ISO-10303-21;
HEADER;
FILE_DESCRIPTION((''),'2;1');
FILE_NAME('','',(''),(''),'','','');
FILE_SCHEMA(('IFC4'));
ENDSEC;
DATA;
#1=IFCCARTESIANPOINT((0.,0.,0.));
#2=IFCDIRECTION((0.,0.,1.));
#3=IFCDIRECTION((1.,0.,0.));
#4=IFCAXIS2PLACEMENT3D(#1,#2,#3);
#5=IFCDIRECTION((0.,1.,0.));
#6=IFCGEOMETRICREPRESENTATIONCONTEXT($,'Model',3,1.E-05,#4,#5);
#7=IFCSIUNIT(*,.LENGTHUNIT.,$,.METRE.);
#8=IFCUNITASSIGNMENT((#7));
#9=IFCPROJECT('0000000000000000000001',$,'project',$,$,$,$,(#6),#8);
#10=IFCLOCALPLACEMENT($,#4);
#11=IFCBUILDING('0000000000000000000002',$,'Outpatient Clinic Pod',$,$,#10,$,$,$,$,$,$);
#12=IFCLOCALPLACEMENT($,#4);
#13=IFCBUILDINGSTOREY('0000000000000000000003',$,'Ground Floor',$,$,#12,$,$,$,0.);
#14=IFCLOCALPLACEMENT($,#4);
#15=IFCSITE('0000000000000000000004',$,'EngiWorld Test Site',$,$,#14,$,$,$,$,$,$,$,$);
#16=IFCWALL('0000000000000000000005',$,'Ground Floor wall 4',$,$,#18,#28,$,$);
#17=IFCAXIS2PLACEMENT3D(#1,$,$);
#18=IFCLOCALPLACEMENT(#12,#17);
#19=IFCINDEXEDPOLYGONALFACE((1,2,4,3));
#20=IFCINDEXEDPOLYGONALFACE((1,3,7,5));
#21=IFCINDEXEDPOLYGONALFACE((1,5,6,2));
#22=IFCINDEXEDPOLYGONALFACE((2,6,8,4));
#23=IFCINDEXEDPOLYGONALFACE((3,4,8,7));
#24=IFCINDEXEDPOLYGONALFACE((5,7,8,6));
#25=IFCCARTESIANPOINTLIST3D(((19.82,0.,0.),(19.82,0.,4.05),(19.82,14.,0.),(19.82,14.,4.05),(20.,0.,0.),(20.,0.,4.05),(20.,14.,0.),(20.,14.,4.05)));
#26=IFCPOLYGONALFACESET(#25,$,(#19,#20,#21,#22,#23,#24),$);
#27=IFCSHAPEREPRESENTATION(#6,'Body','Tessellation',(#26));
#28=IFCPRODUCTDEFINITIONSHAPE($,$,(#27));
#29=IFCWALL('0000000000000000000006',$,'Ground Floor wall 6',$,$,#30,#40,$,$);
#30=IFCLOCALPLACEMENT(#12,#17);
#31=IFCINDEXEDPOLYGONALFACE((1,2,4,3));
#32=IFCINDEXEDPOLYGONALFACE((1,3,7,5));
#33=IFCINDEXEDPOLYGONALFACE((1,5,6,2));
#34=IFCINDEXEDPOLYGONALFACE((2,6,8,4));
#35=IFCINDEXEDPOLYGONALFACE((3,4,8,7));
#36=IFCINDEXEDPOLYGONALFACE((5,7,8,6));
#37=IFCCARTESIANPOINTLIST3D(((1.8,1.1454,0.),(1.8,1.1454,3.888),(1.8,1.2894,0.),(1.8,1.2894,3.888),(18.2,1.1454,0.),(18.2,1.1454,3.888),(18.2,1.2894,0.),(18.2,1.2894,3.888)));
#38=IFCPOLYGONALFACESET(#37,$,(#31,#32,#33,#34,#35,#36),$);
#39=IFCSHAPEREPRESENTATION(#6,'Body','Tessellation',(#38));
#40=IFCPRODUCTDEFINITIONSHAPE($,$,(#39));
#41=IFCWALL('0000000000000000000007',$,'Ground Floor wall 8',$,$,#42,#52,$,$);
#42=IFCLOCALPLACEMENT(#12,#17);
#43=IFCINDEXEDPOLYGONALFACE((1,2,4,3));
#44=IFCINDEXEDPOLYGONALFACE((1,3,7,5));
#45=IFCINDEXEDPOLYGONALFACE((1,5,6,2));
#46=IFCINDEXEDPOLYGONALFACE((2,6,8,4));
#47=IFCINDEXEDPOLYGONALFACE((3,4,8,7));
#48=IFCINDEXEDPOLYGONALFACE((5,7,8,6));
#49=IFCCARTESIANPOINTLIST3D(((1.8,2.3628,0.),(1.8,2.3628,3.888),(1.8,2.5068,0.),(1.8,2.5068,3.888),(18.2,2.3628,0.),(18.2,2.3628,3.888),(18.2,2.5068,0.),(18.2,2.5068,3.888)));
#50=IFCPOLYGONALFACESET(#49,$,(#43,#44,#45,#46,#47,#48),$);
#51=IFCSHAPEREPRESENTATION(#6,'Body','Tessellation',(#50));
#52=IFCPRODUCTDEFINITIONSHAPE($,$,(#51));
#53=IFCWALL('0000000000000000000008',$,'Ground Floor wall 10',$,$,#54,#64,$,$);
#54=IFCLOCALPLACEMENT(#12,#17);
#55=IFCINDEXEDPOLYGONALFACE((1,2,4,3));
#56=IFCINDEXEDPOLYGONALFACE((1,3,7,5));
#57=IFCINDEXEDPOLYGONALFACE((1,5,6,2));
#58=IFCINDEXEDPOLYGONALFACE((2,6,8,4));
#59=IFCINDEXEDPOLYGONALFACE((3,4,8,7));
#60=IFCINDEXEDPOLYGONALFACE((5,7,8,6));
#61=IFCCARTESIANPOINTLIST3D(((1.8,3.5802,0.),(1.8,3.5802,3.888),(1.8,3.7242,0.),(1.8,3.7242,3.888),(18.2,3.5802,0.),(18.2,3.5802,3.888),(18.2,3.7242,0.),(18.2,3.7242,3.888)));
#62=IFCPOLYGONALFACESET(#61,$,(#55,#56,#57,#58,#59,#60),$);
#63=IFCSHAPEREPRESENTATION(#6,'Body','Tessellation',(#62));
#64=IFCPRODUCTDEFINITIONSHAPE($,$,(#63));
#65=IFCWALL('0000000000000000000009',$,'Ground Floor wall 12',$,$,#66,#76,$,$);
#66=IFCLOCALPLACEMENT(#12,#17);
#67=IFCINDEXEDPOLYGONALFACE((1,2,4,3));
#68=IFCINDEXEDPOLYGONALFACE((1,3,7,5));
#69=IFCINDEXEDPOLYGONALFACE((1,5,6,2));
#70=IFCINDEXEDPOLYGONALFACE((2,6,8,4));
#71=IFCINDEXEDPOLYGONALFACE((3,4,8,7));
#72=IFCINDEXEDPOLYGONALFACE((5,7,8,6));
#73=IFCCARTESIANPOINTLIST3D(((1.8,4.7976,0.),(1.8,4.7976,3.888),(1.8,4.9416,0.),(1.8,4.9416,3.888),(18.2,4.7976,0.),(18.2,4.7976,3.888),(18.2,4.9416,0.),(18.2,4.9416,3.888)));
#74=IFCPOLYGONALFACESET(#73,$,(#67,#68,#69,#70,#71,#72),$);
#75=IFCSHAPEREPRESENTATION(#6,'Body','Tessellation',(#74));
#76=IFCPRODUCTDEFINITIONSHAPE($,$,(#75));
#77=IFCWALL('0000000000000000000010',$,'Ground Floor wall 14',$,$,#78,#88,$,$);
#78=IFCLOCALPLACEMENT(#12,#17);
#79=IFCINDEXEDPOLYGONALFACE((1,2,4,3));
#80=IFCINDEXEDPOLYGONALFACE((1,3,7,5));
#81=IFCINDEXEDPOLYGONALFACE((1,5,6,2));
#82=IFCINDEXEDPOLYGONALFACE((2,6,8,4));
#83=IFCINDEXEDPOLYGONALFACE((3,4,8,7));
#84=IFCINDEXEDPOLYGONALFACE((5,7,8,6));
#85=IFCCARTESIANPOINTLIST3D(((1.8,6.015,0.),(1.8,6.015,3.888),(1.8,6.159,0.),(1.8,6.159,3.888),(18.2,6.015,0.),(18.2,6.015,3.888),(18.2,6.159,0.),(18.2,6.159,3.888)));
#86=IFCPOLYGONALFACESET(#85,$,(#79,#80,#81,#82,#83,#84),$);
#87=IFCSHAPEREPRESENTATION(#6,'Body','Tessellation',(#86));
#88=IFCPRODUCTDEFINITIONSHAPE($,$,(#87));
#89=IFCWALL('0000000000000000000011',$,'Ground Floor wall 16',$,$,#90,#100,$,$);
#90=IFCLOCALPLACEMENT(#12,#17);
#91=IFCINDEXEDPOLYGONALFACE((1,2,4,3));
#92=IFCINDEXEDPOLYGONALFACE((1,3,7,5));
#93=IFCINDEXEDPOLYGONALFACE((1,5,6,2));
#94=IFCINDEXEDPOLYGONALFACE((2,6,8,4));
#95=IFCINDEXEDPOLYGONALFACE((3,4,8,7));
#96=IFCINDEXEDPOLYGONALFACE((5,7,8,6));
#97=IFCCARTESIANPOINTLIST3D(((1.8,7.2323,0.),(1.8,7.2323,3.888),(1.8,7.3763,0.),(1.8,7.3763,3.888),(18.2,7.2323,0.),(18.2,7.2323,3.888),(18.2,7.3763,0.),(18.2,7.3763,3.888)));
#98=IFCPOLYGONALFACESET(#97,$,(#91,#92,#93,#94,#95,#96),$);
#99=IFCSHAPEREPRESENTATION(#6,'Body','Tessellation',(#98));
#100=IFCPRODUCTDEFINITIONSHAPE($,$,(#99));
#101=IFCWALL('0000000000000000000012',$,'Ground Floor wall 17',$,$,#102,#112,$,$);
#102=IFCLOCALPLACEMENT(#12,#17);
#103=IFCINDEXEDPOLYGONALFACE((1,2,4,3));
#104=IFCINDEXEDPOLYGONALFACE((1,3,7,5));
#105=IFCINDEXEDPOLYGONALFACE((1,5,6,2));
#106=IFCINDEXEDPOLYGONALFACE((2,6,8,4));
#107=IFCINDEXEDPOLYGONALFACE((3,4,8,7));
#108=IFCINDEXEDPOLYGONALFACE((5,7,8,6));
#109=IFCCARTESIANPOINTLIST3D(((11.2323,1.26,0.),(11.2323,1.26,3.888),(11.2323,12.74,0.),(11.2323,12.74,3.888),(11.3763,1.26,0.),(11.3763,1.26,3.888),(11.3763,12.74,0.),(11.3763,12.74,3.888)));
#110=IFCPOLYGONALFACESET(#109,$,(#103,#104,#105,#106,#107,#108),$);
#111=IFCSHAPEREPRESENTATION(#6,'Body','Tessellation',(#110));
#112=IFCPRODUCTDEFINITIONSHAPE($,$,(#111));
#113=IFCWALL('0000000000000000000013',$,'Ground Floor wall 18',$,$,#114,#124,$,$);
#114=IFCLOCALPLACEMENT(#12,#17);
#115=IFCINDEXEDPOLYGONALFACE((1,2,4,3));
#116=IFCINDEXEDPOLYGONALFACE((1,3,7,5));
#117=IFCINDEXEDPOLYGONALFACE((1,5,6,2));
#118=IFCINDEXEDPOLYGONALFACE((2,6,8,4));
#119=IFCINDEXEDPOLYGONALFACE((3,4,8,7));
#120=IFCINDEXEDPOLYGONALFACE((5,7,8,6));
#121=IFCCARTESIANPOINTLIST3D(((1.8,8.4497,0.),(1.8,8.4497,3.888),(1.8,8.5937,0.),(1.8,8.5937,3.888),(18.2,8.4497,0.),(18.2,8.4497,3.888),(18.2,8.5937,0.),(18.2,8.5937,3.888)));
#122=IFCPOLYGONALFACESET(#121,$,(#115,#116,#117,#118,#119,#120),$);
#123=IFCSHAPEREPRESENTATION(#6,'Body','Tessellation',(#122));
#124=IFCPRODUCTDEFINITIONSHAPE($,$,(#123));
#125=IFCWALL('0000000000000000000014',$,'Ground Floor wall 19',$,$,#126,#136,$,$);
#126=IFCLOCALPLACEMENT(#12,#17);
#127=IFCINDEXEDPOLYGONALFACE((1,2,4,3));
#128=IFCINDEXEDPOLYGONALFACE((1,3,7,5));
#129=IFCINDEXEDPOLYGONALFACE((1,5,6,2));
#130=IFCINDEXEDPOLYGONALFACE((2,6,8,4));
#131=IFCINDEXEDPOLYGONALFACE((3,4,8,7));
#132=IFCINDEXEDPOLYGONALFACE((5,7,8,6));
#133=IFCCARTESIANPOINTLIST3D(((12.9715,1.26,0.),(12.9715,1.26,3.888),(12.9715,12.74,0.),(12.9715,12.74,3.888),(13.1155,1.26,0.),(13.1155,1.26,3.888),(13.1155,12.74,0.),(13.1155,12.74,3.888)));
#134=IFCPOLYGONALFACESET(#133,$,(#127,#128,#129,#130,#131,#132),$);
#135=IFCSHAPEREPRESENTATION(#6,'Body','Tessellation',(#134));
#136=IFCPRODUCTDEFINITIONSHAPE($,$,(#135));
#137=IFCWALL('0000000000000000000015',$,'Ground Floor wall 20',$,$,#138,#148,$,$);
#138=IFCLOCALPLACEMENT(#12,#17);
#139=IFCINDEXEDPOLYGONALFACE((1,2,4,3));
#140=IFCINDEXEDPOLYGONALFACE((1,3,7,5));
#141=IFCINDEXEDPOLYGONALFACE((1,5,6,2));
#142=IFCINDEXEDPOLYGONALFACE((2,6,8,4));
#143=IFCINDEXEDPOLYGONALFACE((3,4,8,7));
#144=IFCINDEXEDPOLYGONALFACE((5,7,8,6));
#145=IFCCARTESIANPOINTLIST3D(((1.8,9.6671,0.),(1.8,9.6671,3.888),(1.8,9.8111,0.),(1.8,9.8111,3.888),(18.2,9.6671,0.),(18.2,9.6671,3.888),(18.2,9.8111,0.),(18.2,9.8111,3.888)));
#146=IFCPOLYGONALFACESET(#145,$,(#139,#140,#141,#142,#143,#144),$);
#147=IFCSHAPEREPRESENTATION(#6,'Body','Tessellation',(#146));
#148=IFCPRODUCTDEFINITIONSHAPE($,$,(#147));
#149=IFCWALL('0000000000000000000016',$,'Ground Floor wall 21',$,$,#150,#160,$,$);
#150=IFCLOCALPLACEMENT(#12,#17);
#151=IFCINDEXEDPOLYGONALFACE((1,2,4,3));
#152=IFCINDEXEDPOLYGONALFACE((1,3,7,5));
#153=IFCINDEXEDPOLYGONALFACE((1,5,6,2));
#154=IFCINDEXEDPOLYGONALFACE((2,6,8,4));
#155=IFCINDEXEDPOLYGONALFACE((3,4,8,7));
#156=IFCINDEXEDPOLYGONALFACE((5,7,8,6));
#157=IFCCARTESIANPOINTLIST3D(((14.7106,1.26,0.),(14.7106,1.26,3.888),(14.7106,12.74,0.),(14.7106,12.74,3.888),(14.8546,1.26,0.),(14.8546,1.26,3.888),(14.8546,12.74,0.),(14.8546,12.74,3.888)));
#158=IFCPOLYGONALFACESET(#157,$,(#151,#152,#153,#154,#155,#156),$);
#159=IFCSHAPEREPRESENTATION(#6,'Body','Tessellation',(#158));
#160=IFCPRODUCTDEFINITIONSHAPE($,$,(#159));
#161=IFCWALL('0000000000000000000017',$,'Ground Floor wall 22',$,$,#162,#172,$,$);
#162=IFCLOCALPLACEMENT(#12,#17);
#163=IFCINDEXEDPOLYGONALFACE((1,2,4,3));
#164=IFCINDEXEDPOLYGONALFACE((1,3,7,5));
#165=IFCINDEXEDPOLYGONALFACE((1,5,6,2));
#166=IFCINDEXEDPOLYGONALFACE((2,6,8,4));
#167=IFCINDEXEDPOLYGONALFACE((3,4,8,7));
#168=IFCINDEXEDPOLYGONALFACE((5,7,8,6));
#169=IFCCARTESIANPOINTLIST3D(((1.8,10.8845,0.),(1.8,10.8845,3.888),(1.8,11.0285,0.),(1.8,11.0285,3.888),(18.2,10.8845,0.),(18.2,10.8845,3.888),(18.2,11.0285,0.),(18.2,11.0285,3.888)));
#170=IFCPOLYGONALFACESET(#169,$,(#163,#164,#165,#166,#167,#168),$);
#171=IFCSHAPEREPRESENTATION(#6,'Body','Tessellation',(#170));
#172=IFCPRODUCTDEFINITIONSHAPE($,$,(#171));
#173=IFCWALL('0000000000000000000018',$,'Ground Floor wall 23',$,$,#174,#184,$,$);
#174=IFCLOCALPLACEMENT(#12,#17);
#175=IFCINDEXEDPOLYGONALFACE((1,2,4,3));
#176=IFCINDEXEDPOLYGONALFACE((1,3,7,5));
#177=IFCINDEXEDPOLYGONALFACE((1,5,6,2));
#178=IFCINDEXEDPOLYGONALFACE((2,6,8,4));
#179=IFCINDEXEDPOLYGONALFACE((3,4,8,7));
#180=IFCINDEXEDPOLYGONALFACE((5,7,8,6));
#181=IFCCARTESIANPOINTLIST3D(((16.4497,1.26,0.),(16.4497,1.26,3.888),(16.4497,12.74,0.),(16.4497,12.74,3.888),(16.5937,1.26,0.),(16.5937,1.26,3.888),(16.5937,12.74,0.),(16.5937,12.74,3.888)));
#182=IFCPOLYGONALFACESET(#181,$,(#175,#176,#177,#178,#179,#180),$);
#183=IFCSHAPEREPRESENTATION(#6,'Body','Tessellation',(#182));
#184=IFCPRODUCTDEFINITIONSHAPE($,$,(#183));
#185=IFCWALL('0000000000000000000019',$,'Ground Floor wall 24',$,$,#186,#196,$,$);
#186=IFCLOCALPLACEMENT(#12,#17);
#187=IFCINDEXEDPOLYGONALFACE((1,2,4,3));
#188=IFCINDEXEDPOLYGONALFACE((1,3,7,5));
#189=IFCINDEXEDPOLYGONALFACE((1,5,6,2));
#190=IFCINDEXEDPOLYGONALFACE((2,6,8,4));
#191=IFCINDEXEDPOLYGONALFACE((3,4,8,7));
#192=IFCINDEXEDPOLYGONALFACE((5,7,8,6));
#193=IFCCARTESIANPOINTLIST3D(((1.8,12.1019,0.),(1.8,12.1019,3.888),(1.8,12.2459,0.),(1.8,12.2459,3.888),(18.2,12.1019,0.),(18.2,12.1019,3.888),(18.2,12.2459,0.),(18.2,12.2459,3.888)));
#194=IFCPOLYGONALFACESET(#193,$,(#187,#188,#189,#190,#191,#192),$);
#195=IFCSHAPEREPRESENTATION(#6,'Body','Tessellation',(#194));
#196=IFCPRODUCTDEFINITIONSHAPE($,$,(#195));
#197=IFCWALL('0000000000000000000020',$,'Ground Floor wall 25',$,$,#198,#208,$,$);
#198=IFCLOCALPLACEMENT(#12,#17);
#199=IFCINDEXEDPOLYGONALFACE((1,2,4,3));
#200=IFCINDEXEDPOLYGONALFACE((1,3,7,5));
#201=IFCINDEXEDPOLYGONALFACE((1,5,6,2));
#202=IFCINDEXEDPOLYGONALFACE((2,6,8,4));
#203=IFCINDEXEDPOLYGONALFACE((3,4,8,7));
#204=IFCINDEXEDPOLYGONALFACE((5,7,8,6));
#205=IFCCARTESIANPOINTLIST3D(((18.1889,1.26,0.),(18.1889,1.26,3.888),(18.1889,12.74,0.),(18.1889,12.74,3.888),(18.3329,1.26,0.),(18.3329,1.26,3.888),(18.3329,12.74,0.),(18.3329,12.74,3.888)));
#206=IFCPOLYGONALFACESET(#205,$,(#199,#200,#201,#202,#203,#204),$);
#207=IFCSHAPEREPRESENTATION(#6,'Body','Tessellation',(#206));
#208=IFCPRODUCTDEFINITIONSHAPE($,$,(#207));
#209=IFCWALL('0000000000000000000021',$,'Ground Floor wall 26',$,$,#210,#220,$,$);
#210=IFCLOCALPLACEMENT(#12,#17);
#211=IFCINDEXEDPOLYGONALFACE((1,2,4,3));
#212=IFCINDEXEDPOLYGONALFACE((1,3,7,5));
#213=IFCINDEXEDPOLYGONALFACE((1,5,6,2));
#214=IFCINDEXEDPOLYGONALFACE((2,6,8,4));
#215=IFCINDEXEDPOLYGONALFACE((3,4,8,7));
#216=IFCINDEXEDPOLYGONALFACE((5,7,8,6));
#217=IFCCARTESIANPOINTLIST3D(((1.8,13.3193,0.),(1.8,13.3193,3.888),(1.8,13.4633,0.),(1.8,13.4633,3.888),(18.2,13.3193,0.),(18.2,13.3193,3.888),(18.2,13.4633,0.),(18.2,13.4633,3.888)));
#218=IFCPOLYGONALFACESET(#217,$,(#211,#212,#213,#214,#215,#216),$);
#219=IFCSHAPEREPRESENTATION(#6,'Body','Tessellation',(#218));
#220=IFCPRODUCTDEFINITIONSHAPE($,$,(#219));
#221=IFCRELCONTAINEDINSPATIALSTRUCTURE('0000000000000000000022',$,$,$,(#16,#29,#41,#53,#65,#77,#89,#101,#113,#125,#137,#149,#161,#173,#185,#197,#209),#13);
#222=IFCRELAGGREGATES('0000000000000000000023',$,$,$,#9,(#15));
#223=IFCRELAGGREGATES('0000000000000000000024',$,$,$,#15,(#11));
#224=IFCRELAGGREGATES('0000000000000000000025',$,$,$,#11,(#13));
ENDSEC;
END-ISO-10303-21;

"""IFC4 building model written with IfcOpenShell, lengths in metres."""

from ifc_helpers import new_model, si_unit, direction, frame, origin_with_axes, origin_2d_with_axis, place, context, project, spatial, rectangle, extrude, element, save


model = new_model("IFC4")

# Units and contexts
model_context = context("Model", 3, precision=1e-05, world=origin_with_axes(), true_north=direction((0.0, 1.0, 0.0)))
ifc_project = project(units=[si_unit("LENGTHUNIT", "METRE")], contexts=[model_context])

# Site, building, storey
site_placement = place(None, origin_with_axes())
site = spatial("IfcSite", under=ifc_project, at=site_placement, Name="EngiWorld Test Site")
building_placement = place(None, origin_with_axes())
building = spatial("IfcBuilding", under=site, at=building_placement, Name="Outpatient Clinic Pod")
storey_placement = place(None, origin_with_axes())
storey = spatial("IfcBuildingStorey", under=building, at=storey_placement, Name="Ground Floor", Elevation=0.0)

# Walls
wall_1_placement = place(None, frame((19.91, 7.0, 0.0), z_axis=(0.0, 0.0, 1.0), x_axis=(1.0, 0.0, 0.0)))
element("IfcWall", 1, at=wall_1_placement, inside=storey, Name="Ground Floor wall 4", context=model_context, shape_type="SweptSolid", body=[
    extrude(rectangle(XDim=0.18, YDim=14.0, at=origin_2d_with_axis()), origin_with_axes(), (0.0, 0.0, 1.0), 4.05),
])
for number, where, z_axis, x_axis, name in (
    (2, (10.0, 1.2174, 0.0), (0.0, 0.0, 1.0), (1.0, 0.0, 0.0), "Ground Floor wall 6"),
    (3, (10.0, 2.4348, 0.0), (0.0, 0.0, 1.0), (1.0, 0.0, 0.0), "Ground Floor wall 8"),
    (4, (10.0, 3.6522, 0.0), (0.0, 0.0, 1.0), (1.0, 0.0, 0.0), "Ground Floor wall 10"),
    (5, (10.0, 4.8696, 0.0), (0.0, 0.0, 1.0), (1.0, 0.0, 0.0), "Ground Floor wall 12"),
    (6, (10.0, 6.087, 0.0), (0.0, 0.0, 1.0), (1.0, 0.0, 0.0), "Ground Floor wall 14"),
    (7, (10.0, 7.3043, 0.0), (0.0, 0.0, 1.0), (1.0, 0.0, 0.0), "Ground Floor wall 16"),
):
    element("IfcWall", number, at=place(None, frame(where, z_axis=z_axis, x_axis=x_axis)), inside=storey, Name=name, context=model_context, shape_type="SweptSolid", body=[
        extrude(rectangle(XDim=16.4, YDim=0.144, at=origin_2d_with_axis()), origin_with_axes(), (0.0, 0.0, 1.0), 3.888),
    ])
wall_2_placement = place(None, frame((11.3043, 7.0, 0.0), z_axis=(0.0, 0.0, 1.0), x_axis=(1.0, 0.0, 0.0)))
element("IfcWall", 8, at=wall_2_placement, inside=storey, Name="Ground Floor wall 17", context=model_context, shape_type="SweptSolid", body=[
    extrude(rectangle(XDim=0.144, YDim=11.48, at=origin_2d_with_axis()), origin_with_axes(), (0.0, 0.0, 1.0), 3.888),
])
wall_3_placement = place(None, frame((10.0, 8.5217, 0.0), z_axis=(0.0, 0.0, 1.0), x_axis=(1.0, 0.0, 0.0)))
element("IfcWall", 9, at=wall_3_placement, inside=storey, Name="Ground Floor wall 18", context=model_context, shape_type="SweptSolid", body=[
    extrude(rectangle(XDim=16.4, YDim=0.144, at=origin_2d_with_axis()), origin_with_axes(), (0.0, 0.0, 1.0), 3.888),
])
wall_4_placement = place(None, frame((13.0435, 7.0, 0.0), z_axis=(0.0, 0.0, 1.0), x_axis=(1.0, 0.0, 0.0)))
element("IfcWall", 10, at=wall_4_placement, inside=storey, Name="Ground Floor wall 19", context=model_context, shape_type="SweptSolid", body=[
    extrude(rectangle(XDim=0.144, YDim=11.48, at=origin_2d_with_axis()), origin_with_axes(), (0.0, 0.0, 1.0), 3.888),
])
wall_5_placement = place(None, frame((10.0, 9.7391, 0.0), z_axis=(0.0, 0.0, 1.0), x_axis=(1.0, 0.0, 0.0)))
element("IfcWall", 11, at=wall_5_placement, inside=storey, Name="Ground Floor wall 20", context=model_context, shape_type="SweptSolid", body=[
    extrude(rectangle(XDim=16.4, YDim=0.144, at=origin_2d_with_axis()), origin_with_axes(), (0.0, 0.0, 1.0), 3.888),
])
wall_6_placement = place(None, frame((14.7826, 7.0, 0.0), z_axis=(0.0, 0.0, 1.0), x_axis=(1.0, 0.0, 0.0)))
element("IfcWall", 12, at=wall_6_placement, inside=storey, Name="Ground Floor wall 21", context=model_context, shape_type="SweptSolid", body=[
    extrude(rectangle(XDim=0.144, YDim=11.48, at=origin_2d_with_axis()), origin_with_axes(), (0.0, 0.0, 1.0), 3.888),
])
wall_7_placement = place(None, frame((10.0, 10.9565, 0.0), z_axis=(0.0, 0.0, 1.0), x_axis=(1.0, 0.0, 0.0)))
element("IfcWall", 13, at=wall_7_placement, inside=storey, Name="Ground Floor wall 22", context=model_context, shape_type="SweptSolid", body=[
    extrude(rectangle(XDim=16.4, YDim=0.144, at=origin_2d_with_axis()), origin_with_axes(), (0.0, 0.0, 1.0), 3.888),
])
wall_8_placement = place(None, frame((16.5217, 7.0, 0.0), z_axis=(0.0, 0.0, 1.0), x_axis=(1.0, 0.0, 0.0)))
element("IfcWall", 14, at=wall_8_placement, inside=storey, Name="Ground Floor wall 23", context=model_context, shape_type="SweptSolid", body=[
    extrude(rectangle(XDim=0.144, YDim=11.48, at=origin_2d_with_axis()), origin_with_axes(), (0.0, 0.0, 1.0), 3.888),
])
wall_9_placement = place(None, frame((10.0, 12.1739, 0.0), z_axis=(0.0, 0.0, 1.0), x_axis=(1.0, 0.0, 0.0)))
element("IfcWall", 15, at=wall_9_placement, inside=storey, Name="Ground Floor wall 24", context=model_context, shape_type="SweptSolid", body=[
    extrude(rectangle(XDim=16.4, YDim=0.144, at=origin_2d_with_axis()), origin_with_axes(), (0.0, 0.0, 1.0), 3.888),
])
wall_10_placement = place(None, frame((18.2609, 7.0, 0.0), z_axis=(0.0, 0.0, 1.0), x_axis=(1.0, 0.0, 0.0)))
element("IfcWall", 16, at=wall_10_placement, inside=storey, Name="Ground Floor wall 25", context=model_context, shape_type="SweptSolid", body=[
    extrude(rectangle(XDim=0.144, YDim=11.48, at=origin_2d_with_axis()), origin_with_axes(), (0.0, 0.0, 1.0), 3.888),
])
wall_11_placement = place(None, frame((10.0, 13.3913, 0.0), z_axis=(0.0, 0.0, 1.0), x_axis=(1.0, 0.0, 0.0)))
element("IfcWall", 17, at=wall_11_placement, inside=storey, Name="Ground Floor wall 26", context=model_context, shape_type="SweptSolid", body=[
    extrude(rectangle(XDim=16.4, YDim=0.144, at=origin_2d_with_axis()), origin_with_axes(), (0.0, 0.0, 1.0), 3.888),
])

save(model, "model.ifc")
